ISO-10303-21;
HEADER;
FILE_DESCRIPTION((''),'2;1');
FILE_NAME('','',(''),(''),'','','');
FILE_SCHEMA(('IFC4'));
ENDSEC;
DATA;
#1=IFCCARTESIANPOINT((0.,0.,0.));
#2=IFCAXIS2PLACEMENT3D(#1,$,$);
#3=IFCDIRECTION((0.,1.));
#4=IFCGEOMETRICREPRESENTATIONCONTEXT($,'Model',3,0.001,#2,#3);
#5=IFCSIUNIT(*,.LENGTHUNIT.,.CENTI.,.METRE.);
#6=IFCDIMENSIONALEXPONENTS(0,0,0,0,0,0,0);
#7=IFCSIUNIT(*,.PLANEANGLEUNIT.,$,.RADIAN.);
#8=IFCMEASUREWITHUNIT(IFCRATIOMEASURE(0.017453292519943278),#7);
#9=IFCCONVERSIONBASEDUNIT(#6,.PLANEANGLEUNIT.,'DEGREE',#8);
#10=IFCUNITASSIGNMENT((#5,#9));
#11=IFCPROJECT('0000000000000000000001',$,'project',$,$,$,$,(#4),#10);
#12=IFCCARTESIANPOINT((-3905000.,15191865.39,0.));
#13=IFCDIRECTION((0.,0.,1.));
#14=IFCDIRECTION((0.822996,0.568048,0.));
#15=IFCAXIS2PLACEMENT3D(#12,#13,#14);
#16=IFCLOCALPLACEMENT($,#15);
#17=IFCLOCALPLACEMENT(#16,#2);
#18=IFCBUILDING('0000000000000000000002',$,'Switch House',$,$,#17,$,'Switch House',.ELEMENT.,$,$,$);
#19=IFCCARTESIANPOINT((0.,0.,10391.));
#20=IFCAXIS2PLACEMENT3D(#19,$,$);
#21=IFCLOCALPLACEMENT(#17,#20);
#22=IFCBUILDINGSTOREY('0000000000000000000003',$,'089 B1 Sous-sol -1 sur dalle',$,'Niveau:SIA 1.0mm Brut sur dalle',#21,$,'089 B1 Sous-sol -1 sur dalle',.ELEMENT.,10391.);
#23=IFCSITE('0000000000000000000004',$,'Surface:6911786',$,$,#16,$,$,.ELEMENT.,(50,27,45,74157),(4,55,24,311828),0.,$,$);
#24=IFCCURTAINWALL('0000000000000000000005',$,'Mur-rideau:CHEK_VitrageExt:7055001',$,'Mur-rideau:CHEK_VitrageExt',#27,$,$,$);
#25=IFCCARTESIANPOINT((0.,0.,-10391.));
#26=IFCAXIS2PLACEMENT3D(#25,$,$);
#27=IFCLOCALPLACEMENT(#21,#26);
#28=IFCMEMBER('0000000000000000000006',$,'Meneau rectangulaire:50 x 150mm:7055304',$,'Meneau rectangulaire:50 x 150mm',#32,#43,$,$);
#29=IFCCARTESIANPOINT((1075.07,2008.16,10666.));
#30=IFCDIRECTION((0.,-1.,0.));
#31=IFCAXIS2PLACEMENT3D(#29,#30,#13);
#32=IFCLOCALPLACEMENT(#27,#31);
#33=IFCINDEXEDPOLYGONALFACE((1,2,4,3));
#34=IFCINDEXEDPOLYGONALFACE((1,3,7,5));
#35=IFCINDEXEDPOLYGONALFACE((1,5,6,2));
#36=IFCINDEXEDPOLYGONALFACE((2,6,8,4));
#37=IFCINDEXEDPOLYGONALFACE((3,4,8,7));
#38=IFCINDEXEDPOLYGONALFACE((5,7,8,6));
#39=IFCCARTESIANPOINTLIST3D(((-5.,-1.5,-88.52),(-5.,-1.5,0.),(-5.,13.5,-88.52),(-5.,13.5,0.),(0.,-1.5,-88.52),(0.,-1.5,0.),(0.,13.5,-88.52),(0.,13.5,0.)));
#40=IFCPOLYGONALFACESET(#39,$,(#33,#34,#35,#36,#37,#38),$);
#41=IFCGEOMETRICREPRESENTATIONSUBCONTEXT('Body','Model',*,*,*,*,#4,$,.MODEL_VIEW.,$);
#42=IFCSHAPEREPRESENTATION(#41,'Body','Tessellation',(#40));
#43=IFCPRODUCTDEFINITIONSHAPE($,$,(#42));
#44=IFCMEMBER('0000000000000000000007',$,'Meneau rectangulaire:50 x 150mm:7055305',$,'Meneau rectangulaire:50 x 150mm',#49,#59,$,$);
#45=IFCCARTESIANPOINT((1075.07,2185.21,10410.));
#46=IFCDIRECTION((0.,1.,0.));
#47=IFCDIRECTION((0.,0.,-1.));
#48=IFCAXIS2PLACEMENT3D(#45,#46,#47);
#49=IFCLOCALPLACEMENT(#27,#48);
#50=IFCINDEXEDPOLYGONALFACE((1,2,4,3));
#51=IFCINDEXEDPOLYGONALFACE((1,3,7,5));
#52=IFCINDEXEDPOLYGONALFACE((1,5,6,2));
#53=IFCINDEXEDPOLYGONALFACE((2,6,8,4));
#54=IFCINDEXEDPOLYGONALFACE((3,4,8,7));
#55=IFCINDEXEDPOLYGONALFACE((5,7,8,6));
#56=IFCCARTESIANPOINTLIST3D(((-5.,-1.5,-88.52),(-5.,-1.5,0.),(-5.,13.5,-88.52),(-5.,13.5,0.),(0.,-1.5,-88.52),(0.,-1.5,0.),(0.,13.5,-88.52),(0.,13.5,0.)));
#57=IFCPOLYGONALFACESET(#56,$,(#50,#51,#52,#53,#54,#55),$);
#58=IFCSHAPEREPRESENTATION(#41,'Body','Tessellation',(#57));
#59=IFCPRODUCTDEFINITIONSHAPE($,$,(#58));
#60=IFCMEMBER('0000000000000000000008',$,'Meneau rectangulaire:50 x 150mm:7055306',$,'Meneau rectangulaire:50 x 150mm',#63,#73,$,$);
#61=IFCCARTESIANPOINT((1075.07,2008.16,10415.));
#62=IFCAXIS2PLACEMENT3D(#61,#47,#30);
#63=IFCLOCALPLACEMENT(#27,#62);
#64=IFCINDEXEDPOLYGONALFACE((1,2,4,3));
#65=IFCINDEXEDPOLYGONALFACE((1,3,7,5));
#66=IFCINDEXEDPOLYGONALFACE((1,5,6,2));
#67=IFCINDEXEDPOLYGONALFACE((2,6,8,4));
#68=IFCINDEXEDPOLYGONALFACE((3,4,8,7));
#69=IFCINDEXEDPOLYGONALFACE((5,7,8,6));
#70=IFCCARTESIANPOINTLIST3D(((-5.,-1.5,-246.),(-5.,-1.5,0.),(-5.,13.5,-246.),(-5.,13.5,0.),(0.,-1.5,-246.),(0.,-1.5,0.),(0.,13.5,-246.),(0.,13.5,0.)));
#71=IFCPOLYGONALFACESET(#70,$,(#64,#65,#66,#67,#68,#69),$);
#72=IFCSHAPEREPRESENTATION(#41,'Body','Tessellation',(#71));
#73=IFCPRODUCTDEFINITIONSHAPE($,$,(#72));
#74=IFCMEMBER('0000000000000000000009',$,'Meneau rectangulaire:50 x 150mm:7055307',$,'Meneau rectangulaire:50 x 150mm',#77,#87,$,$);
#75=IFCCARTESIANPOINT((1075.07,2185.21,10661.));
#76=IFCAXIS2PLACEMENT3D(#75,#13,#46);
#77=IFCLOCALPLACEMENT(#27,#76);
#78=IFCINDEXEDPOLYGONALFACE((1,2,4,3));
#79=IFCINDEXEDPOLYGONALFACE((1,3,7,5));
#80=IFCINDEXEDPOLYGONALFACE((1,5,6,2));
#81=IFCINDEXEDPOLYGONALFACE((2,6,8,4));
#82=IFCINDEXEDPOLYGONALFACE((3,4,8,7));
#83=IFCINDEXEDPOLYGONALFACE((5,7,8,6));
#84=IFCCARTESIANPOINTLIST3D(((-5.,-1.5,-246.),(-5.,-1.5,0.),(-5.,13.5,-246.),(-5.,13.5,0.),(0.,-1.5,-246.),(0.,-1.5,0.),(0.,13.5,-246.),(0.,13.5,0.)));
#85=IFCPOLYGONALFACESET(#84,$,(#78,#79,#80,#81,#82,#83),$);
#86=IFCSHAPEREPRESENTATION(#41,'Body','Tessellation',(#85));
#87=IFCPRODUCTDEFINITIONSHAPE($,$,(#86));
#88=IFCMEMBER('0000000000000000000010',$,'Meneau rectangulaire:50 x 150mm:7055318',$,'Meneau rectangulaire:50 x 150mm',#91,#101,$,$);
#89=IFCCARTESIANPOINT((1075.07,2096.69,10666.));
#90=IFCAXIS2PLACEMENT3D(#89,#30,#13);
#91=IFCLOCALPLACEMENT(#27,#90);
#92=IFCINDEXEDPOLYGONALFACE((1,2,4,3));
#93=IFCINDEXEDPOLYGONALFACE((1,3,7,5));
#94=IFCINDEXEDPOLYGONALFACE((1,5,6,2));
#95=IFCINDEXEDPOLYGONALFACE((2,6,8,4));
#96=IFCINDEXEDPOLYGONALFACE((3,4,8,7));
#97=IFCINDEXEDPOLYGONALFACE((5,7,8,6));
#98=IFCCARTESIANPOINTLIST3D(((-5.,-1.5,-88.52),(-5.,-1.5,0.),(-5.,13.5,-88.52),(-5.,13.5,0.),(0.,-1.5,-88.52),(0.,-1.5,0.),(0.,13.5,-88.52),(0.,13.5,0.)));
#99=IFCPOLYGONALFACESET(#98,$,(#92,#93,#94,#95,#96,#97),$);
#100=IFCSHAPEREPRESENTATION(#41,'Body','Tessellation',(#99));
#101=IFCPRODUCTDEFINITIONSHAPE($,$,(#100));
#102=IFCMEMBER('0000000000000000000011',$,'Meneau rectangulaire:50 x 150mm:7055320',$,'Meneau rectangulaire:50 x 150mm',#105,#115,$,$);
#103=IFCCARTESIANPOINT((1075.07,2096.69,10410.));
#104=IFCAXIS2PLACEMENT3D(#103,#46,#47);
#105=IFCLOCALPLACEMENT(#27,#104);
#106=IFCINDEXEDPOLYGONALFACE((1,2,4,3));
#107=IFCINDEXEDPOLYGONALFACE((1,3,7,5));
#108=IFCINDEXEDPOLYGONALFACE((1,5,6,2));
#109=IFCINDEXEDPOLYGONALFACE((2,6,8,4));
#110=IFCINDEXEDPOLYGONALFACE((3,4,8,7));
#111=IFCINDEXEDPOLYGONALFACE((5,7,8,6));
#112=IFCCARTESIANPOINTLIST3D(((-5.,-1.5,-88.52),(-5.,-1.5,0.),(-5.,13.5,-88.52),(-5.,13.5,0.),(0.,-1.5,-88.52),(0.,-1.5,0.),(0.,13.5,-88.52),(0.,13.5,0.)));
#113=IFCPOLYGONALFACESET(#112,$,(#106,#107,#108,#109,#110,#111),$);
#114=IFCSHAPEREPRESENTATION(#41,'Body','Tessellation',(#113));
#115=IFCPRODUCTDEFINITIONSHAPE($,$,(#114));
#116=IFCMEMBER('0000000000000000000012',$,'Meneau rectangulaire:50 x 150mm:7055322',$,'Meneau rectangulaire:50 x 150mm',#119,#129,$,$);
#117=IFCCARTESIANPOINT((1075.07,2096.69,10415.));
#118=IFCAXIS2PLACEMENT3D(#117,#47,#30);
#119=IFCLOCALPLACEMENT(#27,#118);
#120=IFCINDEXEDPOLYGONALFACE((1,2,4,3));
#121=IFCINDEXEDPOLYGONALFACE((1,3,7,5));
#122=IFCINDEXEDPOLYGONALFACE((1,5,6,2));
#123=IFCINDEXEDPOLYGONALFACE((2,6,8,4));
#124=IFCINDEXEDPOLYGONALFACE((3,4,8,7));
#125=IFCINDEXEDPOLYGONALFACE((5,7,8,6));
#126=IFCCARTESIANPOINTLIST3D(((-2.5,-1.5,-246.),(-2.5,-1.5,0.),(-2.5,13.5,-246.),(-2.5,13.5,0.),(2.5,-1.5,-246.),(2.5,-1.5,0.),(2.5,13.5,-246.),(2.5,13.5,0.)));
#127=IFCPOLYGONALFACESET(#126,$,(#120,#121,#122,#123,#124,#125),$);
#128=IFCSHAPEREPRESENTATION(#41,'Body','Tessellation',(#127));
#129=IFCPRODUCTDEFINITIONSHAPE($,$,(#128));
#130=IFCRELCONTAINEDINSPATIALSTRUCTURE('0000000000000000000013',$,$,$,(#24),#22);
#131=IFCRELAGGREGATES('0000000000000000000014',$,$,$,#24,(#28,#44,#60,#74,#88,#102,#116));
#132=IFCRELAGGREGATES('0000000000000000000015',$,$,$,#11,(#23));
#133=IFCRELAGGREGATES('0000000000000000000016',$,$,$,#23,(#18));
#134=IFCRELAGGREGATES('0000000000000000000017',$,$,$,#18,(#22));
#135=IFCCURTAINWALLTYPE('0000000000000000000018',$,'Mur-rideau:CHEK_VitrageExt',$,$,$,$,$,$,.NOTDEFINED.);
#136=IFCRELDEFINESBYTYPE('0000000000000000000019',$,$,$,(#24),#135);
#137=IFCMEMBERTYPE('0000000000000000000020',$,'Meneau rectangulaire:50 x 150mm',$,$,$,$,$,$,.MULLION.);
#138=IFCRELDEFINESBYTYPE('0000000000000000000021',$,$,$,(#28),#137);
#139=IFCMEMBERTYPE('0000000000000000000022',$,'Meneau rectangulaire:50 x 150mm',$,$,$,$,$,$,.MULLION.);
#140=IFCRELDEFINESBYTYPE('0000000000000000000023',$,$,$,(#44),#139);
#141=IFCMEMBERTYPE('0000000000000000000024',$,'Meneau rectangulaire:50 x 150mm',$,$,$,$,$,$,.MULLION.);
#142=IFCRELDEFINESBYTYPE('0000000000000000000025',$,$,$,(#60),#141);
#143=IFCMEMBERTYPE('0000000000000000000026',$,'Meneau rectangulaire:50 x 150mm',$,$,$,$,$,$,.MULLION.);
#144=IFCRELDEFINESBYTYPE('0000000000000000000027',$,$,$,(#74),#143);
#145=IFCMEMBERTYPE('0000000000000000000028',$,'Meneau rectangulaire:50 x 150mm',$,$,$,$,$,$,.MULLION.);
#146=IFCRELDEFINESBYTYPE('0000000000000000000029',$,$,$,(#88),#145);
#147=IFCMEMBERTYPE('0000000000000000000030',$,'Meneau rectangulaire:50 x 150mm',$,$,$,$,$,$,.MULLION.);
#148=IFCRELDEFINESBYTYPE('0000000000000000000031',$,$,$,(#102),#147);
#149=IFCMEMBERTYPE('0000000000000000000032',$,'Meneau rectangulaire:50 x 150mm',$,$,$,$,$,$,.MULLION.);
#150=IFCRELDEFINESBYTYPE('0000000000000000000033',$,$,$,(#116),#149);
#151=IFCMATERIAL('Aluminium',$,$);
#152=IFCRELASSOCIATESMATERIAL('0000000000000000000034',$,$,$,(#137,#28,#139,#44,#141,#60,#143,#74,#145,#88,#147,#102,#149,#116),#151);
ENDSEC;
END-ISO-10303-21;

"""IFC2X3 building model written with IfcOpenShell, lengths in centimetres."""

from ifc_helpers import new_model, entity, si_unit, converted_unit, direction, frame, origin, origin_2d_with_axis, place, context, subcontext, project, spatial, rectangle, extrude, source, transform, mapped, material, type_object, type_shapes, element, aggregate, save


model = new_model("IFC2X3")

# Units and contexts
model_context = context("Model", 3, precision=0.001, world=origin(), true_north=direction((0.0, 1.0)))
body_context = subcontext(model_context, "Body", "Model", "MODEL_VIEW")
ifc_project = project(units=[si_unit("LENGTHUNIT", "METRE", prefix="CENTI"), converted_unit("PLANEANGLEUNIT", "DEGREE", entity("IfcRatioMeasure", 0.017453292519943278), si_unit("PLANEANGLEUNIT", "RADIAN"), dimensions=[0, 0, 0, 0, 0, 0, 0])], contexts=[model_context])

# Site, building, storey
site_placement = place(None, frame((-3905000.0, 15191865.39, 0.0), z_axis=(0.0, 0.0, 1.0), x_axis=(0.822996, 0.568048, 0.0)))
site = spatial("IfcSite", under=ifc_project, at=site_placement, Name="Surface:6911786", CompositionType="ELEMENT", RefLatitude=(50, 27, 45, 74157), RefLongitude=(4, 55, 24, 311828), RefElevation=0.0)
building_placement = place(site_placement, origin())
building = spatial("IfcBuilding", under=site, at=building_placement, Name="Switch House", LongName="Switch House", CompositionType="ELEMENT")
storey_placement = place(building_placement, frame((0.0, 0.0, 10391.0)))
storey = spatial("IfcBuildingStorey", under=building, at=storey_placement, Name="089 B1 Sous-sol -1 sur dalle", ObjectType="Niveau:SIA 1.0mm Brut sur dalle", LongName="089 B1 Sous-sol -1 sur dalle", CompositionType="ELEMENT", Elevation=10391.0)

# Curtain wall, members
curtain_wall_type = type_object("IfcCurtainWallType", Name="Mur-rideau:CHEK_VitrageExt", PredefinedType="NOTDEFINED")
curtain_wall_placement = place(storey_placement, frame((0.0, 0.0, -10391.0)))
curtain_wall = element("IfcCurtainWall", 1, at=curtain_wall_placement, inside=storey, type_object=curtain_wall_type, Name="Mur-rideau:CHEK_VitrageExt:7055001", ObjectType="Mur-rideau:CHEK_VitrageExt")
ifc_material_1 = material(Name="Aluminium")
member_type_1 = type_object("IfcMemberType", Name="Meneau rectangulaire:50 x 150mm", PredefinedType="MULLION", material=ifc_material_1)
shared_shape_1 = source(origin(), body_context, "Body", "SweptSolid", [
    extrude(rectangle(XDim=15.0, YDim=5.0, at=origin_2d_with_axis()), frame((-2.5, 6.0, -88.52), z_axis=(0.0, 0.0, 1.0), x_axis=(0.0, -1.0, 0.0)), (0.0, 0.0, 1.0), 88.52),
])
type_shapes(member_type_1, [shared_shape_1])
member_1_placement = place(curtain_wall_placement, frame((1075.07, 2008.16, 10666.0), z_axis=(0.0, -1.0, 0.0), x_axis=(0.0, 0.0, 1.0)))
member_1 = element("IfcMember", 2, at=member_1_placement, type_object=member_type_1, material=ifc_material_1, Name="Meneau rectangulaire:50 x 150mm:7055304", ObjectType="Meneau rectangulaire:50 x 150mm", context=body_context, shape_type="MappedRepresentation", body=[
    mapped(shared_shape_1, transform((0.0, 0.0, 0.0), scale=1.0)),
])
member_type_2 = type_object("IfcMemberType", Name="Meneau rectangulaire:50 x 150mm", PredefinedType="MULLION", material=ifc_material_1)
shared_shape_2 = source(origin(), body_context, "Body", "SweptSolid", [
    extrude(rectangle(XDim=15.0, YDim=5.0, at=origin_2d_with_axis()), frame((-2.5, 6.0, -88.52), z_axis=(0.0, 0.0, 1.0), x_axis=(0.0, -1.0, 0.0)), (0.0, 0.0, 1.0), 88.52),
])
type_shapes(member_type_2, [shared_shape_2])
member_2_placement = place(curtain_wall_placement, frame((1075.07, 2185.21, 10410.0), z_axis=(0.0, 1.0, 0.0), x_axis=(0.0, 0.0, -1.0)))
member_2 = element("IfcMember", 3, at=member_2_placement, type_object=member_type_2, material=ifc_material_1, Name="Meneau rectangulaire:50 x 150mm:7055305", ObjectType="Meneau rectangulaire:50 x 150mm", context=body_context, shape_type="MappedRepresentation", body=[
    mapped(shared_shape_2, transform((0.0, 0.0, 0.0), scale=1.0)),
])
member_type_3 = type_object("IfcMemberType", Name="Meneau rectangulaire:50 x 150mm", PredefinedType="MULLION", material=ifc_material_1)
shared_shape_3 = source(origin(), body_context, "Body", "SweptSolid", [
    extrude(rectangle(XDim=15.0, YDim=5.0, at=origin_2d_with_axis()), frame((-2.5, 6.0, -246.0), z_axis=(0.0, 0.0, 1.0), x_axis=(0.0, -1.0, 0.0)), (0.0, 0.0, 1.0), 246.0),
])
type_shapes(member_type_3, [shared_shape_3])
member_3_placement = place(curtain_wall_placement, frame((1075.07, 2008.16, 10415.0), z_axis=(0.0, 0.0, -1.0), x_axis=(0.0, -1.0, 0.0)))
member_3 = element("IfcMember", 4, at=member_3_placement, type_object=member_type_3, material=ifc_material_1, Name="Meneau rectangulaire:50 x 150mm:7055306", ObjectType="Meneau rectangulaire:50 x 150mm", context=body_context, shape_type="MappedRepresentation", body=[
    mapped(shared_shape_3, transform((0.0, 0.0, 0.0), scale=1.0)),
])
member_type_4 = type_object("IfcMemberType", Name="Meneau rectangulaire:50 x 150mm", PredefinedType="MULLION", material=ifc_material_1)
shared_shape_4 = source(origin(), body_context, "Body", "SweptSolid", [
    extrude(rectangle(XDim=15.0, YDim=5.0, at=origin_2d_with_axis()), frame((-2.5, 6.0, -246.0), z_axis=(0.0, 0.0, 1.0), x_axis=(0.0, -1.0, 0.0)), (0.0, 0.0, 1.0), 246.0),
])
type_shapes(member_type_4, [shared_shape_4])
member_4_placement = place(curtain_wall_placement, frame((1075.07, 2185.21, 10661.0), z_axis=(0.0, 0.0, 1.0), x_axis=(0.0, 1.0, 0.0)))
member_4 = element("IfcMember", 5, at=member_4_placement, type_object=member_type_4, material=ifc_material_1, Name="Meneau rectangulaire:50 x 150mm:7055307", ObjectType="Meneau rectangulaire:50 x 150mm", context=body_context, shape_type="MappedRepresentation", body=[
    mapped(shared_shape_4, transform((0.0, 0.0, 0.0), scale=1.0)),
])
member_type_5 = type_object("IfcMemberType", Name="Meneau rectangulaire:50 x 150mm", PredefinedType="MULLION", material=ifc_material_1)
shared_shape_5 = source(origin(), body_context, "Body", "SweptSolid", [
    extrude(rectangle(XDim=15.0, YDim=5.0, at=origin_2d_with_axis()), frame((-2.5, 6.0, -88.52), z_axis=(0.0, 0.0, 1.0), x_axis=(0.0, -1.0, 0.0)), (0.0, 0.0, 1.0), 88.52),
])
type_shapes(member_type_5, [shared_shape_5])
member_5_placement = place(curtain_wall_placement, frame((1075.07, 2096.69, 10666.0), z_axis=(0.0, -1.0, 0.0), x_axis=(0.0, 0.0, 1.0)))
member_5 = element("IfcMember", 6, at=member_5_placement, type_object=member_type_5, material=ifc_material_1, Name="Meneau rectangulaire:50 x 150mm:7055318", ObjectType="Meneau rectangulaire:50 x 150mm", context=body_context, shape_type="MappedRepresentation", body=[
    mapped(shared_shape_5, transform((0.0, 0.0, 0.0), scale=1.0)),
])
member_type_6 = type_object("IfcMemberType", Name="Meneau rectangulaire:50 x 150mm", PredefinedType="MULLION", material=ifc_material_1)
shared_shape_6 = source(origin(), body_context, "Body", "SweptSolid", [
    extrude(rectangle(XDim=15.0, YDim=5.0, at=origin_2d_with_axis()), frame((-2.5, 6.0, -88.52), z_axis=(0.0, 0.0, 1.0), x_axis=(0.0, -1.0, 0.0)), (0.0, 0.0, 1.0), 88.52),
])
type_shapes(member_type_6, [shared_shape_6])
member_6_placement = place(curtain_wall_placement, frame((1075.07, 2096.69, 10410.0), z_axis=(0.0, 1.0, 0.0), x_axis=(0.0, 0.0, -1.0)))
member_6 = element("IfcMember", 7, at=member_6_placement, type_object=member_type_6, material=ifc_material_1, Name="Meneau rectangulaire:50 x 150mm:7055320", ObjectType="Meneau rectangulaire:50 x 150mm", context=body_context, shape_type="MappedRepresentation", body=[
    mapped(shared_shape_6, transform((0.0, 0.0, 0.0), scale=1.0)),
])
member_type_7 = type_object("IfcMemberType", Name="Meneau rectangulaire:50 x 150mm", PredefinedType="MULLION", material=ifc_material_1)
shared_shape_7 = source(origin(), body_context, "Body", "SweptSolid", [
    extrude(rectangle(XDim=15.0, YDim=5.0, at=origin_2d_with_axis()), frame((0.0, 6.0, -246.0), z_axis=(0.0, 0.0, 1.0), x_axis=(0.0, -1.0, 0.0)), (0.0, 0.0, 1.0), 246.0),
])
type_shapes(member_type_7, [shared_shape_7])
member_7_placement = place(curtain_wall_placement, frame((1075.07, 2096.69, 10415.0), z_axis=(0.0, 0.0, -1.0), x_axis=(0.0, -1.0, 0.0)))
member_7 = element("IfcMember", 8, at=member_7_placement, type_object=member_type_7, material=ifc_material_1, Name="Meneau rectangulaire:50 x 150mm:7055322", ObjectType="Meneau rectangulaire:50 x 150mm", context=body_context, shape_type="MappedRepresentation", body=[
    mapped(shared_shape_7, transform((0.0, 0.0, 0.0), scale=1.0)),
])
aggregate(curtain_wall, [member_1, member_2, member_3, member_4, member_5, member_6, member_7])

save(model, "model.ifc")
